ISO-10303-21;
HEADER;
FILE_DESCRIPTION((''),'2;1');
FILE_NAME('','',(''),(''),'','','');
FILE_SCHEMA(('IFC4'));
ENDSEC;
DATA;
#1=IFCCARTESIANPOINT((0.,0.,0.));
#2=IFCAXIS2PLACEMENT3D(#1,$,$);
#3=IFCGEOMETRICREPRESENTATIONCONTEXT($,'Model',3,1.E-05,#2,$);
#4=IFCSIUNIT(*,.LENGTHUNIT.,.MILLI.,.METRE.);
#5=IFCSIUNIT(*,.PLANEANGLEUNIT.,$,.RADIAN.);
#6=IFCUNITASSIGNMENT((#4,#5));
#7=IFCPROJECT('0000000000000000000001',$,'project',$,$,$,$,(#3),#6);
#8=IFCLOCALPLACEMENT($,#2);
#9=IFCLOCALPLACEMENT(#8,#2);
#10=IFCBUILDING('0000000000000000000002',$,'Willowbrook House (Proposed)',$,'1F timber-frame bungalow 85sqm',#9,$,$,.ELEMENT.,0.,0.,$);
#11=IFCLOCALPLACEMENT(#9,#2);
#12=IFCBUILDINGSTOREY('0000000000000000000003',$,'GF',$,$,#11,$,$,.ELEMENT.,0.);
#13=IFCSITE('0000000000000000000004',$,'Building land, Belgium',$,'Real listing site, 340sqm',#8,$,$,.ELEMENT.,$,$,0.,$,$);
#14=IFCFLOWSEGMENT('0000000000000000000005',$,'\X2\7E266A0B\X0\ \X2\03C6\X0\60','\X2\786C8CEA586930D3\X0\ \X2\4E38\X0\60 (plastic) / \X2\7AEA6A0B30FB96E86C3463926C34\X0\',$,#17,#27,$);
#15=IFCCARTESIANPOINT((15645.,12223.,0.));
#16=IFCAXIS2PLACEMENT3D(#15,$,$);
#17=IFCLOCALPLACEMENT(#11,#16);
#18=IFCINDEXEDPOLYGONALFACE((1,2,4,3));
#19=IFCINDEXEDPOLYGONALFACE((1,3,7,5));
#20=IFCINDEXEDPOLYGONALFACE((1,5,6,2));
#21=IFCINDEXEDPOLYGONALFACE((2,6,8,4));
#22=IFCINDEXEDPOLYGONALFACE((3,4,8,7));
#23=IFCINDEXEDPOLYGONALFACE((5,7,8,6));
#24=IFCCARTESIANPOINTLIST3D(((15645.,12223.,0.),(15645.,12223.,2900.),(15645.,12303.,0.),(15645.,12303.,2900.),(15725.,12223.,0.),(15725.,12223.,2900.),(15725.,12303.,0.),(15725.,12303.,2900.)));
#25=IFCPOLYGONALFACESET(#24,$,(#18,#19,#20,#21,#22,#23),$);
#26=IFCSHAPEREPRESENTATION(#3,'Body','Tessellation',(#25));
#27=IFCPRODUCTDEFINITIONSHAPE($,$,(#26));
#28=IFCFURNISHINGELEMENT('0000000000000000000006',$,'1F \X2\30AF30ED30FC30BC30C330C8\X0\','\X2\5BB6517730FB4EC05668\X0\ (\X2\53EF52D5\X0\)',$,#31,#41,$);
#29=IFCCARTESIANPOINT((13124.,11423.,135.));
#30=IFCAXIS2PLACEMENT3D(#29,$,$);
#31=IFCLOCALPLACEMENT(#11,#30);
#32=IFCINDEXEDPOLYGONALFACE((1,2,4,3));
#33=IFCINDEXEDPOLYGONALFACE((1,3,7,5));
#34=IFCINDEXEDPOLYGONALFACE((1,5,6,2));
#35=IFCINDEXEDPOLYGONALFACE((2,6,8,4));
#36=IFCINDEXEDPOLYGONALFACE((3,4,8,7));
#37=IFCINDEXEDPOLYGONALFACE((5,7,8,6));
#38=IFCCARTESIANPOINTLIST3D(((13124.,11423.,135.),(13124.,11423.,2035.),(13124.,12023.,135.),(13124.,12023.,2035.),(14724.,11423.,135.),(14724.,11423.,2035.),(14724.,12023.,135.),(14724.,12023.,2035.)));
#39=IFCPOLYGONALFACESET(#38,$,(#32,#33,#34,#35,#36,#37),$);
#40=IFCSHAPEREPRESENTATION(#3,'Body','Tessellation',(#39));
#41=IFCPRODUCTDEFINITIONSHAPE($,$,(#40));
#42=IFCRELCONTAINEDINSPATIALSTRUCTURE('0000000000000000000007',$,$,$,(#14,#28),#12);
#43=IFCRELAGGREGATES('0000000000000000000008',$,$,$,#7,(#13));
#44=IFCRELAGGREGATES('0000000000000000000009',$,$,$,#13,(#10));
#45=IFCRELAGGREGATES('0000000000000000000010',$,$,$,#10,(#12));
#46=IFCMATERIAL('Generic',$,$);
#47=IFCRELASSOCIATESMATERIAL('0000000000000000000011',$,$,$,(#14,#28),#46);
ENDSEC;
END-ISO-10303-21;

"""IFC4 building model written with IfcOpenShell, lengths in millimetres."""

from ifc_helpers import new_model, si_unit, frame, frame_2d, origin, place, context, project, spatial, rectangle, extrude, material, element, save


model = new_model("IFC4")

# Units and contexts
model_context = context("Model", 3, precision=1e-05, world=origin())
ifc_project = project(units=[si_unit("LENGTHUNIT", "METRE", prefix="MILLI"), si_unit("PLANEANGLEUNIT", "RADIAN")], contexts=[model_context])

# Site, building, storey
site_placement = place(None, origin())
site = spatial("IfcSite", under=ifc_project, at=site_placement, Name="Building land, Belgium", ObjectType="Real listing site, 340sqm", CompositionType="ELEMENT", RefElevation=0.0)
building_placement = place(site_placement, origin())
building = spatial("IfcBuilding", under=site, at=building_placement, Name="Willowbrook House (Proposed)", ObjectType="1F timber-frame bungalow 85sqm", CompositionType="ELEMENT", ElevationOfRefHeight=0.0, ElevationOfTerrain=0.0)
storey_placement = place(building_placement, origin())
storey = spatial("IfcBuildingStorey", under=building, at=storey_placement, Name="GF", CompositionType="ELEMENT", Elevation=0.0)

# Shared definitions
ifc_material_1 = material(Name="Generic")

# Flow segment
flow_segment_placement = place(storey_placement, frame((15645.0, 12223.0, 0.0)))
element("IfcFlowSegment", 1, at=flow_segment_placement, inside=storey, material=ifc_material_1, Name="縦樋 φ60", Description="硬質塩ビ 丸60 (plastic) / 竪樋・雨水排水", context=model_context, shape_type="SweptSolid", body=[
    extrude(rectangle(XDim=80.0, YDim=80.0, at=frame_2d((40.0, 40.0))), frame((15645.0, 12223.0, 0.0)), (0.0, 0.0, 1.0), 2900.0),
])

# Furnishing element
furnishing_placement = place(storey_placement, frame((13124.0, 11423.0, 135.0)))
element("IfcFurnishingElement", 2, at=furnishing_placement, inside=storey, material=ifc_material_1, Name="1F クローゼット", Description="家具・什器 (可動)", context=model_context, shape_type="SweptSolid", body=[
    extrude(rectangle(XDim=1600.0, YDim=600.0, at=frame_2d((800.0, 300.0))), frame((13124.0, 11423.0, 135.0)), (0.0, 0.0, 1.0), 1900.0),
])

save(model, "model.ifc")
